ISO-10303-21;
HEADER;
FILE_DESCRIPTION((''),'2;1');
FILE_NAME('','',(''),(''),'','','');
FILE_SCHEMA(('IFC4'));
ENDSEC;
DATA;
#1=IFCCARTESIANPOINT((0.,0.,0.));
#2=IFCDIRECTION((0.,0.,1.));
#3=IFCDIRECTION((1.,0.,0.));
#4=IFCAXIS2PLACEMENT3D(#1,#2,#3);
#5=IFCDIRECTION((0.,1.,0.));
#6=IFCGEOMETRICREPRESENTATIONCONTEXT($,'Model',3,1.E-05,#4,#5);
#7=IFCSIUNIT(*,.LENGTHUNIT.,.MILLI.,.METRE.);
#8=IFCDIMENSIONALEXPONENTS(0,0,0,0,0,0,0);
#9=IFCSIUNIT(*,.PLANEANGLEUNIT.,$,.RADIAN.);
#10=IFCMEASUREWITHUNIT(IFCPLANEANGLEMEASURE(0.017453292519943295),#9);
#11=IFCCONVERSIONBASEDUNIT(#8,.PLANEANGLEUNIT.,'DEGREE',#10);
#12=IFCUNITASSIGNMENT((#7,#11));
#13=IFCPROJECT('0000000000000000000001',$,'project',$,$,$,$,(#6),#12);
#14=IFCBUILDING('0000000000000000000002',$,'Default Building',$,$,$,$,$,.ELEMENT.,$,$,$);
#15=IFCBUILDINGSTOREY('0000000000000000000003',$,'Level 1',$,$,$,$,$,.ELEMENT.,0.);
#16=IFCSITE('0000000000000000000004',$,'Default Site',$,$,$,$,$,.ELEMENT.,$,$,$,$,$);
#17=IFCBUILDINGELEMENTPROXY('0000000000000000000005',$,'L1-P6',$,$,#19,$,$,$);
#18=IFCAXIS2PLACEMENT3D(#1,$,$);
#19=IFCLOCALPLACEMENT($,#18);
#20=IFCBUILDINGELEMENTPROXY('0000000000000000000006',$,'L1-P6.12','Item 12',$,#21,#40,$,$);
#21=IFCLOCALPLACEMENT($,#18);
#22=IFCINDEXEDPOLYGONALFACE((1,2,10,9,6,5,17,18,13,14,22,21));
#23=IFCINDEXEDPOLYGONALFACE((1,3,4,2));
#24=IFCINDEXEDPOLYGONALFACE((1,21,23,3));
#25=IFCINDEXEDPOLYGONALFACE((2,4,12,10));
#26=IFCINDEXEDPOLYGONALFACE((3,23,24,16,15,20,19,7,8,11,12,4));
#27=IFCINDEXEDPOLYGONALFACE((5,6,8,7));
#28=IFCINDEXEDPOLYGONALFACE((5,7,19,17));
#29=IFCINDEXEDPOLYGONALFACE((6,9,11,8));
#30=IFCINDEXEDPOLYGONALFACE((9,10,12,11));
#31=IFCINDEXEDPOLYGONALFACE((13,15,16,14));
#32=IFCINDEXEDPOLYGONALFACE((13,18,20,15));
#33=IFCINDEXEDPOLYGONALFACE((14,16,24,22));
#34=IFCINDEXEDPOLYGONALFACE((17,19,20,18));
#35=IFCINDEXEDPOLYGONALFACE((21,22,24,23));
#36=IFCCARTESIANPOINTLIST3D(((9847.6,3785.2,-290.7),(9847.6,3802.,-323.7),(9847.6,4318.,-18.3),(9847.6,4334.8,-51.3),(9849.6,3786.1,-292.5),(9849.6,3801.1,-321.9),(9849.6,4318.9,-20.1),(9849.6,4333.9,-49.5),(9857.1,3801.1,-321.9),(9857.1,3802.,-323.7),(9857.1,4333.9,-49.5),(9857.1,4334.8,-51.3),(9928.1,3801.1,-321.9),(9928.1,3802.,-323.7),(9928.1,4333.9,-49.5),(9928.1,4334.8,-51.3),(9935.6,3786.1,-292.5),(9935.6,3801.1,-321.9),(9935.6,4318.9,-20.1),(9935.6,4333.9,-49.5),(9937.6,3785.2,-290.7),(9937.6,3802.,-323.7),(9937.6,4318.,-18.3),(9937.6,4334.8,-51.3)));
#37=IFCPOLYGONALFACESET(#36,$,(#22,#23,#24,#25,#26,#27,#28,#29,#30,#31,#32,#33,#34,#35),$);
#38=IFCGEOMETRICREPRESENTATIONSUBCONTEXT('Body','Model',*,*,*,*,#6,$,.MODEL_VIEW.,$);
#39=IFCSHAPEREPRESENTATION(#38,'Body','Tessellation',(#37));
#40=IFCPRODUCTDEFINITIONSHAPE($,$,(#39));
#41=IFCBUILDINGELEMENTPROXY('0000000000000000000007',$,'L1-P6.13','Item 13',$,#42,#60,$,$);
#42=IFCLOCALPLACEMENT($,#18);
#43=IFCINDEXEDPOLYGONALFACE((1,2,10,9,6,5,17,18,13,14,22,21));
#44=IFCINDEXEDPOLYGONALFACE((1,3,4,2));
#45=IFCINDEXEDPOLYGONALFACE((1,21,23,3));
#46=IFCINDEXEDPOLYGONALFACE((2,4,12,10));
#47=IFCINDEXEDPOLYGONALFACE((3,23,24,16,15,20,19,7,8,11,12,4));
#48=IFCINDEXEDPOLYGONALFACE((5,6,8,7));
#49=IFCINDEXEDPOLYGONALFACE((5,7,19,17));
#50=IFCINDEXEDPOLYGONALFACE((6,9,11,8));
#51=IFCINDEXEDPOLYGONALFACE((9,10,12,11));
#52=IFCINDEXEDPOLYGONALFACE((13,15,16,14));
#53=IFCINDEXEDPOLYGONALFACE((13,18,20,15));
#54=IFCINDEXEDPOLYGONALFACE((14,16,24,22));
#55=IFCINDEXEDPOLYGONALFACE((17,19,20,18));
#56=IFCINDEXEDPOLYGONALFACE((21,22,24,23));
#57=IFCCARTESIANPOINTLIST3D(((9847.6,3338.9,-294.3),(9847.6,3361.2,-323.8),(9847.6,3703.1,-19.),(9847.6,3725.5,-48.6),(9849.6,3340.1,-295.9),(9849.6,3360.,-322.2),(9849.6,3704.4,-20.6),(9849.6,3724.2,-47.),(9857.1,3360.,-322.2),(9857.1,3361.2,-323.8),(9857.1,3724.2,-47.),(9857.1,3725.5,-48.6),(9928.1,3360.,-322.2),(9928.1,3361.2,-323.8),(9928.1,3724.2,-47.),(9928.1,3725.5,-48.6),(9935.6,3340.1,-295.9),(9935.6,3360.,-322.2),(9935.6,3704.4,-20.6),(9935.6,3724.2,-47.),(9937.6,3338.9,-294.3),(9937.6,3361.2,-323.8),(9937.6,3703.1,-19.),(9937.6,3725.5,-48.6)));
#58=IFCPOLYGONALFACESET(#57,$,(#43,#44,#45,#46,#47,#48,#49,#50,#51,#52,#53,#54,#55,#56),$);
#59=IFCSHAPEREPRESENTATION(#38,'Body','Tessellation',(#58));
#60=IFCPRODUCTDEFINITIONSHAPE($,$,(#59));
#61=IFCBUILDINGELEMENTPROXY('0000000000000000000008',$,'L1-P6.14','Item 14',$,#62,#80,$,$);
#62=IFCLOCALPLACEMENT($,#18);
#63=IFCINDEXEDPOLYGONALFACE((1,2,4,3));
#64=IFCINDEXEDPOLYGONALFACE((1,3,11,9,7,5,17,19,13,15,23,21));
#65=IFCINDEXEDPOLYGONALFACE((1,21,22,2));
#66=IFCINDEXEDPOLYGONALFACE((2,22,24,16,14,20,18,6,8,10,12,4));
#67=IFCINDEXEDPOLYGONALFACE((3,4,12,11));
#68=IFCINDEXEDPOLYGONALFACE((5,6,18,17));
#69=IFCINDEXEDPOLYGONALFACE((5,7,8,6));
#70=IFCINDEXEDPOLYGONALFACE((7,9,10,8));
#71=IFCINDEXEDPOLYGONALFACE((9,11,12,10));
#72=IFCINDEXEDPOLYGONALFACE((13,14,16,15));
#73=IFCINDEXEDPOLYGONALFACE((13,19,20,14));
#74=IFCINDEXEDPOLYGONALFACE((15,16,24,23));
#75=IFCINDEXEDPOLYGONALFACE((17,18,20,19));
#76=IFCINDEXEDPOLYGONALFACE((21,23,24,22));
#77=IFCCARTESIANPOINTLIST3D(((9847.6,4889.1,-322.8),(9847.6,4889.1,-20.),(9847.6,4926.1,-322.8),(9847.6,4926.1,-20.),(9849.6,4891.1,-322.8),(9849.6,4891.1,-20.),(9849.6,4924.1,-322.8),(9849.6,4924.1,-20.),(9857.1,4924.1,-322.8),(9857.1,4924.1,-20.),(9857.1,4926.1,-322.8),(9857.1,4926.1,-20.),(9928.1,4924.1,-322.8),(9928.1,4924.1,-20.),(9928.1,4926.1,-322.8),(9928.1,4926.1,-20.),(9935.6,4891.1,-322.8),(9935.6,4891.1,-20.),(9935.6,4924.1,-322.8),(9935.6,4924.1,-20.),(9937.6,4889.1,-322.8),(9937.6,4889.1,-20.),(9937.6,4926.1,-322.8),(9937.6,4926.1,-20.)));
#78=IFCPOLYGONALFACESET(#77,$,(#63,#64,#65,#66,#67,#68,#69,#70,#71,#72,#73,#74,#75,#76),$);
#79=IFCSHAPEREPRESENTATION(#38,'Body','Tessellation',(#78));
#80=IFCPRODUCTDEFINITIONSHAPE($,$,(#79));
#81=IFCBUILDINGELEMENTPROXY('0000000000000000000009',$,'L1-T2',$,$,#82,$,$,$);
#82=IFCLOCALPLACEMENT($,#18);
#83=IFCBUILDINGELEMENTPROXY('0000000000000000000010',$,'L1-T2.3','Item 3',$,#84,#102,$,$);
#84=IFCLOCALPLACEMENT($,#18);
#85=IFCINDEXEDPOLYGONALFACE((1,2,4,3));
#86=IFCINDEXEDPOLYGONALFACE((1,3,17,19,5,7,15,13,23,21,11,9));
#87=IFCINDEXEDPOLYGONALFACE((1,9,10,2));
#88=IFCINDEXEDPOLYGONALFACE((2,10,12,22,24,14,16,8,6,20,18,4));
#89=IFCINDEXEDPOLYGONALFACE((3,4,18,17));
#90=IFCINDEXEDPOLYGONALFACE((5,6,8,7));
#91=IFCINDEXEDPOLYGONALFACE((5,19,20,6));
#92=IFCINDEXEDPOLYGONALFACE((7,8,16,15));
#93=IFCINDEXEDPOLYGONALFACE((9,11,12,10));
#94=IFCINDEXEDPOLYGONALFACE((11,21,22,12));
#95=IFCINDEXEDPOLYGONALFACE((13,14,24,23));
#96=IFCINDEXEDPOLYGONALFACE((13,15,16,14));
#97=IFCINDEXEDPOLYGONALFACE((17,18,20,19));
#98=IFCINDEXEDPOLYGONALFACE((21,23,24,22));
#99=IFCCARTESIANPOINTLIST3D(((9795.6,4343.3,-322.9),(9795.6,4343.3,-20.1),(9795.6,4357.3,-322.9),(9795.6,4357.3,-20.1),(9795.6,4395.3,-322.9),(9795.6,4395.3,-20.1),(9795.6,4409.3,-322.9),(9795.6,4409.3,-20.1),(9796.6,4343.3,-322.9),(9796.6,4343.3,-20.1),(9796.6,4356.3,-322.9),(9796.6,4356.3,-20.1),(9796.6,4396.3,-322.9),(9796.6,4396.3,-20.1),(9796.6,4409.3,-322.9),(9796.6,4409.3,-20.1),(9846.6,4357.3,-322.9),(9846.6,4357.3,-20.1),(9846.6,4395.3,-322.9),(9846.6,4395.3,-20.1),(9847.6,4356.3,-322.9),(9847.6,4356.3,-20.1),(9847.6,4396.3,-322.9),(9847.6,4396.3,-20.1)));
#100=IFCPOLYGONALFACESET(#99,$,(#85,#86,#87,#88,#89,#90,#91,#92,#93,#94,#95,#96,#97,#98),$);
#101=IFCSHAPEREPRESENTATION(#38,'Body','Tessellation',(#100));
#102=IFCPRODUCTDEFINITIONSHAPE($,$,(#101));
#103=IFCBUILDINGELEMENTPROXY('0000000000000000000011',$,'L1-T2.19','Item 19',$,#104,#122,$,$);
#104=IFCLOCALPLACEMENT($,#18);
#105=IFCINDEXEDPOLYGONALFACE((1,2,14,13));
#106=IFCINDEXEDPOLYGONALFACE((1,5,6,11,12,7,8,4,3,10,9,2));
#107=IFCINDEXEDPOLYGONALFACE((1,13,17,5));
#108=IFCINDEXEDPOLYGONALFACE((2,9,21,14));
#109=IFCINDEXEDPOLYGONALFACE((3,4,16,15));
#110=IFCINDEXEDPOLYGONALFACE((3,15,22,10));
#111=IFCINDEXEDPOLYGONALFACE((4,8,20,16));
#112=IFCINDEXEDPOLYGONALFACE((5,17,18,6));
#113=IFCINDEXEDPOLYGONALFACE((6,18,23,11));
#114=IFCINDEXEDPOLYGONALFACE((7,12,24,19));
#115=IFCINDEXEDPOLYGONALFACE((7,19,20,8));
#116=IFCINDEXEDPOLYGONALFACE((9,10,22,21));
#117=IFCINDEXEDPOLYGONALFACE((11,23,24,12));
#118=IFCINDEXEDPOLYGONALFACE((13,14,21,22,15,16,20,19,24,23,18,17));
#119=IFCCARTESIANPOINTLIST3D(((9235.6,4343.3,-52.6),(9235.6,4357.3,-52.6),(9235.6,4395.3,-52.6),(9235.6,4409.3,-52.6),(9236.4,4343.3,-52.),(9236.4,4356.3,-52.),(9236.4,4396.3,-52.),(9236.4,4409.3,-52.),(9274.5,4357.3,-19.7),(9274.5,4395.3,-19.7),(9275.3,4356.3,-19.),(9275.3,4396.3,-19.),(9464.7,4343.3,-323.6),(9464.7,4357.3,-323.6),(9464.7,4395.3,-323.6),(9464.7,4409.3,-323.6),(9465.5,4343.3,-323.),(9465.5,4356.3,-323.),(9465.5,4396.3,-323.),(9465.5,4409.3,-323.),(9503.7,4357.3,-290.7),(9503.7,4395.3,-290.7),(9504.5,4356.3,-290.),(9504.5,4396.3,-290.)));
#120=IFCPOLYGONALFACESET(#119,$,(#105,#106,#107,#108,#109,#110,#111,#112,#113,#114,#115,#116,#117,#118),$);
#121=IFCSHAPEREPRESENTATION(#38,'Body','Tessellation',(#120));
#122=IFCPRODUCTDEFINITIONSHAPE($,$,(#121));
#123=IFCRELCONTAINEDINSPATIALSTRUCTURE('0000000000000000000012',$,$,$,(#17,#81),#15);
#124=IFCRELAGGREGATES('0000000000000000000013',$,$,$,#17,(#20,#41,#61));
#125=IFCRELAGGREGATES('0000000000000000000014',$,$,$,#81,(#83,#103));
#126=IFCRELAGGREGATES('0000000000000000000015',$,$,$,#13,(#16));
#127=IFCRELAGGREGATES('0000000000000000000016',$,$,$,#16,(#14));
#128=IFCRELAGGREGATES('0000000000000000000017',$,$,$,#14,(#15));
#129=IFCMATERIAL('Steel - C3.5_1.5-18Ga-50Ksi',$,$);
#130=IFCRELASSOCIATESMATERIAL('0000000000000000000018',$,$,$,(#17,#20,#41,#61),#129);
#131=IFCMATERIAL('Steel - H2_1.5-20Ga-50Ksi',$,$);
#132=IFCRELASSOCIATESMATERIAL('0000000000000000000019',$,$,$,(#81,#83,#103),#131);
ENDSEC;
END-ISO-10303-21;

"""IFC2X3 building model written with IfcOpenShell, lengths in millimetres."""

from ifc_helpers import new_model, entity, si_unit, converted_unit, direction, frame, origin, origin_with_axes, origin_2d_with_axis, place, context, subcontext, project, spatial, polyline, c_section, outline, extrude, material, element, aggregate, save


model = new_model("IFC2X3")

# Units and contexts
model_context = context("Model", 3, precision=1e-05, world=origin_with_axes(), true_north=direction((0.0, 1.0, 0.0)))
body_context = subcontext(model_context, "Body", "Model", "MODEL_VIEW")
ifc_project = project(units=[si_unit("LENGTHUNIT", "METRE", prefix="MILLI"), converted_unit("PLANEANGLEUNIT", "DEGREE", entity("IfcPlaneAngleMeasure", 0.017453292519943295), si_unit("PLANEANGLEUNIT", "RADIAN"), dimensions=[0, 0, 0, 0, 0, 0, 0])], contexts=[model_context])

# Site, building, storey
site = spatial("IfcSite", under=ifc_project, Name="Default Site", CompositionType="ELEMENT")
building = spatial("IfcBuilding", under=site, Name="Default Building", CompositionType="ELEMENT")
storey = spatial("IfcBuildingStorey", under=building, Name="Level 1", CompositionType="ELEMENT", Elevation=0.0)

# Shared definitions
ifc_material_1 = material(Name="Steel - C3.5_1.5-18Ga-50Ksi")

# Building element proxies
ifc_material_2 = material(Name="Steel - H2_1.5-20Ga-50Ksi")
proxy_1 = element("IfcBuildingElementProxy", 1, inside=storey, material=ifc_material_1, Name="L1-P6")
proxy_2_placement = place(None, frame((9892.6, 4326.4, -34.8), z_axis=(0.0, -0.89, -0.455), x_axis=(0.0, 16.852, -32.94)))
proxy_2 = element("IfcBuildingElementProxy", 2, at=proxy_2_placement, material=ifc_material_1, Name="L1-P6.12", Description="Item 12", context=body_context, shape_type="SweptSolid", body=[
    extrude(c_section(Depth=90.0, Width=37.0, WallThickness=2.0, Girth=9.5, at=origin_2d_with_axis()), origin(), (0.0, 0.0, 1.0), 598.4),
])
proxy_3_placement = place(None, frame((9892.6, 3714.3, -33.8), z_axis=(0.0, -0.798, -0.603), x_axis=(0.0, 22.306, -29.52)))
proxy_3 = element("IfcBuildingElementProxy", 3, at=proxy_3_placement, material=ifc_material_1, Name="L1-P6.13", Description="Item 13", context=body_context, shape_type="SweptSolid", body=[
    extrude(c_section(Depth=90.0, Width=37.0, WallThickness=2.0, Girth=9.5, at=origin_2d_with_axis()), origin(), (0.0, 0.0, 1.0), 456.6),
])
proxy_4_placement = place(None, frame((9892.6, 4907.6, -20.0), z_axis=(0.0, 0.0, -1.0), x_axis=(0.0, 37.0, 0.0)))
proxy_4 = element("IfcBuildingElementProxy", 4, at=proxy_4_placement, material=ifc_material_1, Name="L1-P6.14", Description="Item 14", context=body_context, shape_type="SweptSolid", body=[
    extrude(c_section(Depth=90.0, Width=37.0, WallThickness=2.0, Girth=9.5, at=origin_2d_with_axis()), origin(), (0.0, 0.0, 1.0), 302.8),
])
aggregate(proxy_1, [proxy_2, proxy_3, proxy_4])
proxy_5 = element("IfcBuildingElementProxy", 5, inside=storey, material=ifc_material_2, Name="L1-T2")
proxy_6_placement = place(None, frame((9795.6, 4343.3, -20.1), z_axis=(0.0, 0.0, -1.0), x_axis=(0.0, 40.0, 0.0)))
proxy_6 = element("IfcBuildingElementProxy", 6, at=proxy_6_placement, material=ifc_material_2, Name="L1-T2.3", Description="Item 3", context=body_context, shape_type="SweptSolid", body=[
    extrude(outline(polyline([(0.0, 0.0), (14.0, 0.0), (14.0, 51.0), (52.0, 51.0), (52.0, 0.0), (66.0, 0.0), (66.0, 1.0), (53.0, 1.0), (53.0, 52.0), (13.0, 52.0), (13.0, 1.0), (0.0, 1.0), (0.0, 0.0)])), origin(), (0.0, 0.0, 1.0), 302.8),
])
proxy_7_placement = place(None, frame((9235.6, 4343.3, -52.6), z_axis=(0.646, 0.0, -0.764), x_axis=(0.0, 40.0, 0.0)))
proxy_7 = element("IfcBuildingElementProxy", 7, at=proxy_7_placement, material=ifc_material_2, Name="L1-T2.19", Description="Item 19", context=body_context, shape_type="SweptSolid", body=[
    extrude(outline(polyline([(0.0, 0.0), (14.0, 0.0), (14.0, 51.0), (52.0, 51.0), (52.0, 0.0), (66.0, 0.0), (66.0, 1.0), (53.0, 1.0), (53.0, 52.0), (13.0, 52.0), (13.0, 1.0), (0.0, 1.0), (0.0, 0.0)])), origin(), (0.0, 0.0, 1.0), 354.9),
])
aggregate(proxy_5, [proxy_6, proxy_7])

save(model, "model.ifc")
